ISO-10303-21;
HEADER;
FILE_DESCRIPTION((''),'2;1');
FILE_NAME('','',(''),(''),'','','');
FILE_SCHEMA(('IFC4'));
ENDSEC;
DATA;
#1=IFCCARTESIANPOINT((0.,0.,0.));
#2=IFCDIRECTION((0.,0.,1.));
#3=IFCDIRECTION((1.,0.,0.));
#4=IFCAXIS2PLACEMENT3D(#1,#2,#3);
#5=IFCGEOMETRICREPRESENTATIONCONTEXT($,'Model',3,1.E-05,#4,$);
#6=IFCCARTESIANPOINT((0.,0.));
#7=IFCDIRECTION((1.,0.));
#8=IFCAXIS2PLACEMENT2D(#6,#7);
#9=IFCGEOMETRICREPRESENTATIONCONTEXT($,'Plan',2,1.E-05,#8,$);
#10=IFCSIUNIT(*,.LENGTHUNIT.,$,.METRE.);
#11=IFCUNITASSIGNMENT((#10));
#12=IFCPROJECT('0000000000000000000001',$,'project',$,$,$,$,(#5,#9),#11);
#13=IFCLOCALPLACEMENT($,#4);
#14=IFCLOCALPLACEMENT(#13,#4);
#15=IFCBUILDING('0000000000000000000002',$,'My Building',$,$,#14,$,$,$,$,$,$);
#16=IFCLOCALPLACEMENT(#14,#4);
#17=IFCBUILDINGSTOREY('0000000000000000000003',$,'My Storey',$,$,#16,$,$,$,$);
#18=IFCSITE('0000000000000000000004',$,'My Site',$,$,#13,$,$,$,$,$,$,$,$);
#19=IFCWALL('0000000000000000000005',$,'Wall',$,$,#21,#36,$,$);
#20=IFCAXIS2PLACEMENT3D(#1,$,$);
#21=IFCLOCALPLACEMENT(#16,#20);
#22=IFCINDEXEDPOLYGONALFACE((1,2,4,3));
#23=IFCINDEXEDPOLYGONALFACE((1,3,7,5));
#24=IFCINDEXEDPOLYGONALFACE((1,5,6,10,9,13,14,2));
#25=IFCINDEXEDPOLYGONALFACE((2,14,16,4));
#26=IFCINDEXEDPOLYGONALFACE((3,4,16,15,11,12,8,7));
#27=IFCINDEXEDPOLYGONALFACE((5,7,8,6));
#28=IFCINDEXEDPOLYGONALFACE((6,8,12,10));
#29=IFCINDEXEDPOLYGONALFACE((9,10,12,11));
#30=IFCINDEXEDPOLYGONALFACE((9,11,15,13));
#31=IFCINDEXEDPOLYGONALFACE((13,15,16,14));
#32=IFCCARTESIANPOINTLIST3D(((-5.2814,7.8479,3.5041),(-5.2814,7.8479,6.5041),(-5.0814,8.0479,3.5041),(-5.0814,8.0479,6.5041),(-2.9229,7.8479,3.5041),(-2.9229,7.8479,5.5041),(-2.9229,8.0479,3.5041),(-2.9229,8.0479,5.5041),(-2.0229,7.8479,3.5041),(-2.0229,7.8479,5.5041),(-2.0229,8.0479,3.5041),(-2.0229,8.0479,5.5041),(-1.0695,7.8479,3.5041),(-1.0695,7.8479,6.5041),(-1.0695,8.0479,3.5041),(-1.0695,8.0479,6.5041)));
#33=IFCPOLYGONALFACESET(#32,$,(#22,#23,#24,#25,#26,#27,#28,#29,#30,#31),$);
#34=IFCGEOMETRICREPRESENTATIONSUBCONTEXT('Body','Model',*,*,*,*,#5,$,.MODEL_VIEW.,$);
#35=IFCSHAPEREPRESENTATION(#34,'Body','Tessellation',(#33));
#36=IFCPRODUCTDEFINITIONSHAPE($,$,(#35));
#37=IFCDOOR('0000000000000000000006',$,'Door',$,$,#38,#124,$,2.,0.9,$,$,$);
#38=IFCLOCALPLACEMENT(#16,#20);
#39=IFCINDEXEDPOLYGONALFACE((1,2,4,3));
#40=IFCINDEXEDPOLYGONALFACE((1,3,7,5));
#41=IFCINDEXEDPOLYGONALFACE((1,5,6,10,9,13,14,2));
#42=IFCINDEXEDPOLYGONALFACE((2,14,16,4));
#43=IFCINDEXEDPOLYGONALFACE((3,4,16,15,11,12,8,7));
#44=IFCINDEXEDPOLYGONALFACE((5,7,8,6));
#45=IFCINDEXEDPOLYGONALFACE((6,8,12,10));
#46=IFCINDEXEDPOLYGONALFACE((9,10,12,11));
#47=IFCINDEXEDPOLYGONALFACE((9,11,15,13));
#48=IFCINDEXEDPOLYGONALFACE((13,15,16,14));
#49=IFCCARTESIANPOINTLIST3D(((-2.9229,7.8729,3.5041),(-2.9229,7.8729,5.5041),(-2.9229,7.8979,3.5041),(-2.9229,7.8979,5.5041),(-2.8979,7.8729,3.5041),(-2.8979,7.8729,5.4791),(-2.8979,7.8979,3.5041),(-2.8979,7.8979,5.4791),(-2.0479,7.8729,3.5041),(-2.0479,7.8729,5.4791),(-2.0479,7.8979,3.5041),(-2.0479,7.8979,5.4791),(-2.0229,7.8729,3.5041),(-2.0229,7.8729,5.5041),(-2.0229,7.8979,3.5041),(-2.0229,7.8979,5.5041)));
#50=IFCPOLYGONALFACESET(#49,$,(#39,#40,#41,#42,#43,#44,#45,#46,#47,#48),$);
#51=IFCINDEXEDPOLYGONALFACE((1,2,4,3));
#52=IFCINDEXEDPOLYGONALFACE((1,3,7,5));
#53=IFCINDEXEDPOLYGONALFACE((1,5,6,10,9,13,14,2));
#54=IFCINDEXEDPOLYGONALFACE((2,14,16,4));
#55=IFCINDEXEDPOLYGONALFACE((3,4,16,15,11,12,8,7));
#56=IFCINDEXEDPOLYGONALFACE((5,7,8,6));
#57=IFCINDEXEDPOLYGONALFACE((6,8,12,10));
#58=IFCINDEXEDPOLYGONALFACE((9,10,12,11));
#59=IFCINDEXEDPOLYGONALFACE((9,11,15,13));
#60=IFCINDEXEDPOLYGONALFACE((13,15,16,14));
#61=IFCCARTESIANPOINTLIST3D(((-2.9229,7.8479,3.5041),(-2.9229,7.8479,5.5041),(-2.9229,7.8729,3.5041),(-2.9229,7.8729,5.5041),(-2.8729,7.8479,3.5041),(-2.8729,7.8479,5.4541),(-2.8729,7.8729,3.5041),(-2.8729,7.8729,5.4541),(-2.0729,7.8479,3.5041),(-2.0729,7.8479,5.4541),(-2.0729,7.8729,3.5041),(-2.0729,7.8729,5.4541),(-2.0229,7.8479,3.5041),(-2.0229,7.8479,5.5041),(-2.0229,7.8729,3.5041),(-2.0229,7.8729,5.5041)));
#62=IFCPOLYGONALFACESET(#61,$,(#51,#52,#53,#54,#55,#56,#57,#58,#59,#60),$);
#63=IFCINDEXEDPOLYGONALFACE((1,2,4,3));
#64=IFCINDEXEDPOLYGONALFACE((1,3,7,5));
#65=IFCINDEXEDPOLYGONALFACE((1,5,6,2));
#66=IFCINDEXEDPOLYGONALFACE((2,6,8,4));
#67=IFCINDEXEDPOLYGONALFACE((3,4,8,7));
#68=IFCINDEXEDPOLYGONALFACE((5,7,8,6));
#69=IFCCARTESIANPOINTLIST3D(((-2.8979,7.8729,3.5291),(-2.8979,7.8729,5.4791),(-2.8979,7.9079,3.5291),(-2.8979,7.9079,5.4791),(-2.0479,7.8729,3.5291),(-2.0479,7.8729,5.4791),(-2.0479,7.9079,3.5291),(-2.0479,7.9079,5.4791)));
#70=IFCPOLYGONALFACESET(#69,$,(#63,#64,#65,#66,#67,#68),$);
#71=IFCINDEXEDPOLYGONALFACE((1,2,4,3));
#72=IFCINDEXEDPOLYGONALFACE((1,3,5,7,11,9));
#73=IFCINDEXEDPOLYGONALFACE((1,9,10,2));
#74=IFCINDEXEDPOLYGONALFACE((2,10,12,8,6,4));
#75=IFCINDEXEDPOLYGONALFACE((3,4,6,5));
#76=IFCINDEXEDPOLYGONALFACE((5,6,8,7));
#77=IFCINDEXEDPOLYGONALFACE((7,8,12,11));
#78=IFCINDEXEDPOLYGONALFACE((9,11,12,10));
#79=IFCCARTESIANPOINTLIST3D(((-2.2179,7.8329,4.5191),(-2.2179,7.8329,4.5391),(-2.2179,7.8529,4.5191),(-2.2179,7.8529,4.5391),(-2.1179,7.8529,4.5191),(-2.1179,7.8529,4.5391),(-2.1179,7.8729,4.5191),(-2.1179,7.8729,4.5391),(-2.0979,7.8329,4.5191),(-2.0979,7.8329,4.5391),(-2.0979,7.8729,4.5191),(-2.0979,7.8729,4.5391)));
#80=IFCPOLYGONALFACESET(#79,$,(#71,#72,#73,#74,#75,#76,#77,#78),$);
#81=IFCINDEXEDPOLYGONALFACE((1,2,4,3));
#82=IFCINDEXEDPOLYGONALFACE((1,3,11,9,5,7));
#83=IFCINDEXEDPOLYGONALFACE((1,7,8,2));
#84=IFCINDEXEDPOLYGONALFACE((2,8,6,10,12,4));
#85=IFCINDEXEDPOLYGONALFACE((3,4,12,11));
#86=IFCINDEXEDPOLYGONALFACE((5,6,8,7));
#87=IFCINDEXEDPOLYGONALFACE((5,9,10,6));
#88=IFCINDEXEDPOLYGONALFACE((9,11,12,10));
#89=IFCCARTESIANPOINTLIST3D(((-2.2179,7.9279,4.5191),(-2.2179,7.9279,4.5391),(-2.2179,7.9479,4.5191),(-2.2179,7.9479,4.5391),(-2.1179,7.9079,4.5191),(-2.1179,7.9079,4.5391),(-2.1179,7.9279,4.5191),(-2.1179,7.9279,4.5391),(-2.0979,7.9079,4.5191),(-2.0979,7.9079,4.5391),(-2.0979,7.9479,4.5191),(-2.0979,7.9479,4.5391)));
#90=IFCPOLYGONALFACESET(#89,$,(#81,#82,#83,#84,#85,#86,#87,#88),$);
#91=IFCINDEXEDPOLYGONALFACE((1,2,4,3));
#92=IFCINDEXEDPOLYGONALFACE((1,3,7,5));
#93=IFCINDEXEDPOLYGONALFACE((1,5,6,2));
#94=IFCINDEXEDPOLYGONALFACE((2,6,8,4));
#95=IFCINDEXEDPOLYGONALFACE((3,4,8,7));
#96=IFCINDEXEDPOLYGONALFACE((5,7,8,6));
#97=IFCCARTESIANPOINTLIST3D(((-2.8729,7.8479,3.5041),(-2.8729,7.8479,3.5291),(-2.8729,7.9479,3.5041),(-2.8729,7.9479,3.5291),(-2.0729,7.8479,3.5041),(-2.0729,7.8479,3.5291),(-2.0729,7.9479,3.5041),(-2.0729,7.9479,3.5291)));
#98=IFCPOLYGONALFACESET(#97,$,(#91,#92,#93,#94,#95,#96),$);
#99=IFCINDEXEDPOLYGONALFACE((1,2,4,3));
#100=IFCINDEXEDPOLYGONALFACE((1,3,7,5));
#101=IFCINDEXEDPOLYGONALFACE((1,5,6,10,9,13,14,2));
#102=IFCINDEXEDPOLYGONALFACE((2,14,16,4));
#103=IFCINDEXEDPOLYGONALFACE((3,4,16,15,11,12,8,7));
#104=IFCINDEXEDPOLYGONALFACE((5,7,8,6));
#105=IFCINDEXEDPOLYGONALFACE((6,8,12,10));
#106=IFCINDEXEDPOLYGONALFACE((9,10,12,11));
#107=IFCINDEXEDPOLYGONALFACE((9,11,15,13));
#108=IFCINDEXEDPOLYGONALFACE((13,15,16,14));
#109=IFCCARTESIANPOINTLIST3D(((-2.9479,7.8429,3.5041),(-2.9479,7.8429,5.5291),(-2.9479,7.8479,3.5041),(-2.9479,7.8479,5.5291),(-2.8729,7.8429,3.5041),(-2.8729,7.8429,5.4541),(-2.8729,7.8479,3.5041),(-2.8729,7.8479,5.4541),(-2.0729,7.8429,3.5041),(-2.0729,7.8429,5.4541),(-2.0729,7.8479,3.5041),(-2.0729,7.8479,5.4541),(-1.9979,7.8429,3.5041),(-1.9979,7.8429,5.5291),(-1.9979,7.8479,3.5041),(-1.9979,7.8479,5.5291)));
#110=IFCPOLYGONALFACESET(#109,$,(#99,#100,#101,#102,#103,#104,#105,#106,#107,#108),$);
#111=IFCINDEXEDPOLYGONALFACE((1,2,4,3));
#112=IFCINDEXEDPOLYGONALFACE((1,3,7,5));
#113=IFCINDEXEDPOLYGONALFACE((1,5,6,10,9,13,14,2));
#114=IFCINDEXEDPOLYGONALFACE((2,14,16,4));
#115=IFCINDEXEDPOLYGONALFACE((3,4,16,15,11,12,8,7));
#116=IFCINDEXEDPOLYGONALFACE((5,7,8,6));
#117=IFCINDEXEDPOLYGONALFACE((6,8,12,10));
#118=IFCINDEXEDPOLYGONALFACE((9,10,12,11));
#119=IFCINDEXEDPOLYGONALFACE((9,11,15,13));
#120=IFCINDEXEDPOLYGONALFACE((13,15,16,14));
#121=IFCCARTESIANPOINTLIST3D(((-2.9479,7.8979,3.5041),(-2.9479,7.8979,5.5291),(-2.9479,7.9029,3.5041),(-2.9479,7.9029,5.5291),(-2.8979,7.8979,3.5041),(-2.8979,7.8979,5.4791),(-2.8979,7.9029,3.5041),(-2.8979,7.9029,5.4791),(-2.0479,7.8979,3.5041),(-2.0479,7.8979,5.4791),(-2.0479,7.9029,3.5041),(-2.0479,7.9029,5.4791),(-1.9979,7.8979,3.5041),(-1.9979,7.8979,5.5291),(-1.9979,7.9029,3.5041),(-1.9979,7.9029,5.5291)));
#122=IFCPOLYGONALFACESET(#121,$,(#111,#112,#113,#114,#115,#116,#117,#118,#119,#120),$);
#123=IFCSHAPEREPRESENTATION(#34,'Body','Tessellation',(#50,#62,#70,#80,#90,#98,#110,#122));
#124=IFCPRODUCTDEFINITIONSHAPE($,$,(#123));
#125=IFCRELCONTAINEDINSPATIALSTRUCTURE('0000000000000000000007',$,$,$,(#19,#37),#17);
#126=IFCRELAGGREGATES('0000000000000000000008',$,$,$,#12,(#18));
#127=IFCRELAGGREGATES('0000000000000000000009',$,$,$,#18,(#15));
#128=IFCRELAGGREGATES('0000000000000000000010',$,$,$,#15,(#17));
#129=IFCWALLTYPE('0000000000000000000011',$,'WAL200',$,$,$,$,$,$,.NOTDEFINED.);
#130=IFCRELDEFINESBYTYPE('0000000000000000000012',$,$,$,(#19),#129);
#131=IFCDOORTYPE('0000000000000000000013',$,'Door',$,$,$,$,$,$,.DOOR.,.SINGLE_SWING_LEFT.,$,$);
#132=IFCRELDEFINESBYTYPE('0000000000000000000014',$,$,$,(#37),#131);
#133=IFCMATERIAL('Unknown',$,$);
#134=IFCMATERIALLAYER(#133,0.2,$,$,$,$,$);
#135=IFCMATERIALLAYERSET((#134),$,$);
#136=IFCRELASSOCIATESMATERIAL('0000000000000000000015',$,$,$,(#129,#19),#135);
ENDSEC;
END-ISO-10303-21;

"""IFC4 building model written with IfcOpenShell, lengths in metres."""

from ifc_helpers import new_model, entity, si_unit, frame, origin_with_axes, origin_2d_with_axis, place, context, subcontext, project, spatial, line, indexed_curve, outline, extrude, shape, source, transform, mapped, material, layer, layer_set, layer_usage, type_object, type_shapes, element, fill, save


model = new_model("IFC4")

# Units and contexts
model_context = context("Model", 3, precision=1e-05, world=origin_with_axes())
plan_context = context("Plan", 2, precision=1e-05, world=origin_2d_with_axis())
body_context_1 = subcontext(model_context, "Body", "Model", "MODEL_VIEW")
body_context_2 = subcontext(plan_context, "Body", "Plan", "PLAN_VIEW")
ifc_project = project(units=[si_unit("LENGTHUNIT", "METRE")], contexts=[model_context, plan_context])

# Site, building, storey
site_placement = place(None, origin_with_axes())
site = spatial("IfcSite", under=ifc_project, at=site_placement, Name="My Site")
building_placement = place(site_placement, origin_with_axes())
building = spatial("IfcBuilding", under=site, at=building_placement, Name="My Building")
storey_placement = place(building_placement, origin_with_axes())
storey = spatial("IfcBuildingStorey", under=building, at=storey_placement, Name="My Storey")

# Shared definitions
ifc_material = material(Name="Unknown")

# Shared definitions
ifc_layer = layer(ifc_material, 0.2)
ifc_layer_set = layer_set([ifc_layer])
wall_type = type_object("IfcWallType", Name="WAL200", PredefinedType="NOTDEFINED", material=ifc_layer_set)

# Shared definitions
shared_shape_1 = source(origin_with_axes(), body_context_1, "Body", "SweptSolid", [
    extrude(outline(indexed_curve([(0.0, 0.0), (0.9, 0.0), (0.9, 2.0), (0.0, 2.0)], segments=[line(1, 2, 3, 4, 1)])), frame((0.0, -0.6, 0.0), z_axis=(0.0, -1.0, 0.0), x_axis=(1.0, 0.0, 0.0)), (0.0, 0.0, -1.0), 1.2),
])
door_type = type_object("IfcDoorType", Name="Door", OperationType="SINGLE_SWING_LEFT", PredefinedType="DOOR")
shared_shape_2 = source(origin_with_axes(), body_context_1, "Body", "SweptSolid", [
    extrude(outline(indexed_curve([(0.0, 0.0), (0.0, 2.0), (0.9, 2.0), (0.9, 0.0), (0.875, 0.0), (0.875, 1.975), (0.025, 1.975), (0.025, 0.0)], segments=[line(1, 2, 3, 4, 5, 6, 7, 8, 1)])), frame((0.0, 0.025, 0.0), z_axis=(0.0, -1.0, 0.0), x_axis=(1.0, 0.0, 0.0)), (0.0, 0.0, -1.0), 0.025),
    extrude(outline(indexed_curve([(0.0, 0.0), (0.0, 2.0), (0.9, 2.0), (0.9, 0.0), (0.85, 0.0), (0.85, 1.95), (0.05, 1.95), (0.05, 0.0)], segments=[line(1, 2, 3, 4, 5, 6, 7, 8, 1)])), frame((0.0, 0.0, 0.0), z_axis=(0.0, -1.0, 0.0), x_axis=(1.0, 0.0, 0.0)), (0.0, 0.0, -1.0), 0.025),
    extrude(outline(indexed_curve([(0.0, 0.0), (0.85, 0.0), (0.85, 0.035), (0.0, 0.035)], segments=[line(1, 2, 3, 4, 1)])), frame((0.025, 0.025, 0.025), z_axis=(0.0, 0.0, 1.0), x_axis=(1.0, 0.0, 0.0)), (0.0, 0.0, 1.0), 1.95),
    extrude(outline(indexed_curve([(0.0, 0.0), (0.0, -0.04), (-0.12, -0.04), (-0.12, -0.02), (-0.02, -0.02), (-0.02, 0.0)], segments=[line(1, 2, 3, 4, 5, 6, 1)])), frame((0.825, 0.025, 1.015), z_axis=(0.0, 0.0, 1.0), x_axis=(1.0, 0.0, 0.0)), (0.0, 0.0, 1.0), 0.02),
    extrude(outline(indexed_curve([(0.0, 0.0), (0.0, 0.04), (-0.12, 0.04), (-0.12, 0.02), (-0.02, 0.02), (-0.02, 0.0)], segments=[line(1, 2, 3, 4, 5, 6, 1)])), frame((0.825, 0.06, 1.015), z_axis=(0.0, 0.0, 1.0), x_axis=(1.0, 0.0, 0.0)), (0.0, 0.0, 1.0), 0.02),
    extrude(outline(indexed_curve([(0.0, 0.0), (0.8, 0.0), (0.8, 0.1), (0.0, 0.1)], segments=[line(1, 2, 3, 4, 1)])), frame((0.05, 0.0, 0.0), z_axis=(0.0, 0.0, 1.0), x_axis=(1.0, 0.0, 0.0)), (0.0, 0.0, 1.0), 0.025),
    extrude(outline(indexed_curve([(0.0, 0.0), (0.0, 2.025), (0.95, 2.025), (0.95, 0.0), (0.875, 0.0), (0.875, 1.95), (0.075, 1.95), (0.075, 0.0)], segments=[line(1, 2, 3, 4, 5, 6, 7, 8, 1)])), frame((-0.025, -0.005, 0.0), z_axis=(0.0, -1.0, 0.0), x_axis=(1.0, 0.0, 0.0)), (0.0, 0.0, -1.0), 0.005),
    extrude(outline(indexed_curve([(0.0, 0.0), (0.0, 2.025), (0.95, 2.025), (0.95, 0.0), (0.9, 0.0), (0.9, 1.975), (0.05, 1.975), (0.05, 0.0)], segments=[line(1, 2, 3, 4, 5, 6, 7, 8, 1)])), frame((-0.025, 0.05, 0.0), z_axis=(0.0, -1.0, 0.0), x_axis=(1.0, 0.0, 0.0)), (0.0, 0.0, -1.0), 0.005),
])
shared_shape_3 = source(origin_with_axes(), body_context_2, "Body", "Curve2D", [
    entity("IfcIndexedPolyCurve", entity("IfcCartesianPointList2D", [[0.0, 0.0], [0.0, 0.05], [0.025, 0.05], [0.025, 0.025], [0.05, 0.025], [0.05, 0.0]]), [entity("IfcLineIndex", [1, 2, 3, 4, 5, 6, 1])]),
    entity("IfcIndexedPolyCurve", entity("IfcCartesianPointList2D", [[0.9, 0.0], [0.9, 0.05], [0.875, 0.05], [0.875, 0.025], [0.85, 0.025], [0.85, 0.0]]), [entity("IfcLineIndex", [1, 2, 3, 4, 5, 6, 1])]),
    entity("IfcTrimmedCurve", entity("IfcEllipse", entity("IfcAxis2Placement2D", entity("IfcCartesianPoint", [0.06, 0.05]), entity("IfcDirection", [1.0, 0.0])), 0.815, 0.85), [entity("IfcCartesianPoint", [0.875, 0.05])], [entity("IfcCartesianPoint", [0.06, 0.9])], True, "CARTESIAN"),
    entity("IfcIndexedPolyCurve", entity("IfcCartesianPointList2D", [[0.025, 0.05], [0.06, 0.05], [0.06, 0.9], [0.025, 0.9]]), [entity("IfcLineIndex", [1, 2, 3, 4, 1])]),
])
type_shapes(door_type, [shared_shape_2, shared_shape_3])

# Wall, opening, door
ifc_layer_usage_1 = layer_usage(ifc_layer_set, "AXIS2", "POSITIVE", 0.0)
wall_1_placement = place(storey_placement, frame((-1.0695, 8.0479, 3.5041), z_axis=(0.0, 0.0, 1.0), x_axis=(-1.0, 0.0, 0.0)))
wall_1 = element("IfcWall", 1, at=wall_1_placement, inside=storey, type_object=wall_type, material=ifc_layer_usage_1, Name="Wall", context=body_context_1, shape_type="SweptSolid", body=[
    extrude(outline(indexed_curve([(0.0, 0.0), (0.0, 0.2), (4.2119, 0.2), (4.0119, 0.0)], segments=[line(1, 2, 3, 4, 1)])), origin_with_axes(), (0.0, 0.0, 1.0), 3.0),
])
opening_1_placement = place(wall_1_placement, frame((1.8534, 0.2, 0.0), z_axis=(0.0, 0.0, 1.0), x_axis=(-1.0, 0.0, 0.0)))
opening_1 = element("IfcOpeningElement", 2, at=opening_1_placement, cuts=wall_1, PredefinedType="OPENING", context=body_context_1, shape_type="MappedRepresentation", body=[
    mapped(shared_shape_1, transform((0.0, 0.0, 0.0), x_axis=(1.0, 0.0, 0.0), y_axis=(0.0, 1.0, 0.0), z_axis=(0.0, 0.0, 1.0), scale=1.0)),
])
door_1_placement = place(opening_1_placement, frame((0.0, 0.0, 0.0), z_axis=(0.0, 0.0, 1.0), x_axis=(1.0, 0.0, 0.0)))
door_1 = element("IfcDoor", 3, at=door_1_placement, inside=storey, type_object=door_type, Name="Door", OverallHeight=2.0, OverallWidth=0.9, shapes=[
    shape(body_context_1, "Body", "MappedRepresentation", [mapped(shared_shape_2, transform((0.0, 0.0, 0.0), x_axis=(1.0, 0.0, 0.0), y_axis=(0.0, 1.0, 0.0), z_axis=(0.0, 0.0, 1.0), scale=1.0))]),
    shape(body_context_2, "Body", "MappedRepresentation", [mapped(shared_shape_3, transform((0.0, 0.0, 0.0), x_axis=(1.0, 0.0, 0.0), y_axis=(0.0, 1.0, 0.0), z_axis=(0.0, 0.0, 1.0), scale=1.0))]),
])
fill(opening_1, door_1)

save(model, "model.ifc")
